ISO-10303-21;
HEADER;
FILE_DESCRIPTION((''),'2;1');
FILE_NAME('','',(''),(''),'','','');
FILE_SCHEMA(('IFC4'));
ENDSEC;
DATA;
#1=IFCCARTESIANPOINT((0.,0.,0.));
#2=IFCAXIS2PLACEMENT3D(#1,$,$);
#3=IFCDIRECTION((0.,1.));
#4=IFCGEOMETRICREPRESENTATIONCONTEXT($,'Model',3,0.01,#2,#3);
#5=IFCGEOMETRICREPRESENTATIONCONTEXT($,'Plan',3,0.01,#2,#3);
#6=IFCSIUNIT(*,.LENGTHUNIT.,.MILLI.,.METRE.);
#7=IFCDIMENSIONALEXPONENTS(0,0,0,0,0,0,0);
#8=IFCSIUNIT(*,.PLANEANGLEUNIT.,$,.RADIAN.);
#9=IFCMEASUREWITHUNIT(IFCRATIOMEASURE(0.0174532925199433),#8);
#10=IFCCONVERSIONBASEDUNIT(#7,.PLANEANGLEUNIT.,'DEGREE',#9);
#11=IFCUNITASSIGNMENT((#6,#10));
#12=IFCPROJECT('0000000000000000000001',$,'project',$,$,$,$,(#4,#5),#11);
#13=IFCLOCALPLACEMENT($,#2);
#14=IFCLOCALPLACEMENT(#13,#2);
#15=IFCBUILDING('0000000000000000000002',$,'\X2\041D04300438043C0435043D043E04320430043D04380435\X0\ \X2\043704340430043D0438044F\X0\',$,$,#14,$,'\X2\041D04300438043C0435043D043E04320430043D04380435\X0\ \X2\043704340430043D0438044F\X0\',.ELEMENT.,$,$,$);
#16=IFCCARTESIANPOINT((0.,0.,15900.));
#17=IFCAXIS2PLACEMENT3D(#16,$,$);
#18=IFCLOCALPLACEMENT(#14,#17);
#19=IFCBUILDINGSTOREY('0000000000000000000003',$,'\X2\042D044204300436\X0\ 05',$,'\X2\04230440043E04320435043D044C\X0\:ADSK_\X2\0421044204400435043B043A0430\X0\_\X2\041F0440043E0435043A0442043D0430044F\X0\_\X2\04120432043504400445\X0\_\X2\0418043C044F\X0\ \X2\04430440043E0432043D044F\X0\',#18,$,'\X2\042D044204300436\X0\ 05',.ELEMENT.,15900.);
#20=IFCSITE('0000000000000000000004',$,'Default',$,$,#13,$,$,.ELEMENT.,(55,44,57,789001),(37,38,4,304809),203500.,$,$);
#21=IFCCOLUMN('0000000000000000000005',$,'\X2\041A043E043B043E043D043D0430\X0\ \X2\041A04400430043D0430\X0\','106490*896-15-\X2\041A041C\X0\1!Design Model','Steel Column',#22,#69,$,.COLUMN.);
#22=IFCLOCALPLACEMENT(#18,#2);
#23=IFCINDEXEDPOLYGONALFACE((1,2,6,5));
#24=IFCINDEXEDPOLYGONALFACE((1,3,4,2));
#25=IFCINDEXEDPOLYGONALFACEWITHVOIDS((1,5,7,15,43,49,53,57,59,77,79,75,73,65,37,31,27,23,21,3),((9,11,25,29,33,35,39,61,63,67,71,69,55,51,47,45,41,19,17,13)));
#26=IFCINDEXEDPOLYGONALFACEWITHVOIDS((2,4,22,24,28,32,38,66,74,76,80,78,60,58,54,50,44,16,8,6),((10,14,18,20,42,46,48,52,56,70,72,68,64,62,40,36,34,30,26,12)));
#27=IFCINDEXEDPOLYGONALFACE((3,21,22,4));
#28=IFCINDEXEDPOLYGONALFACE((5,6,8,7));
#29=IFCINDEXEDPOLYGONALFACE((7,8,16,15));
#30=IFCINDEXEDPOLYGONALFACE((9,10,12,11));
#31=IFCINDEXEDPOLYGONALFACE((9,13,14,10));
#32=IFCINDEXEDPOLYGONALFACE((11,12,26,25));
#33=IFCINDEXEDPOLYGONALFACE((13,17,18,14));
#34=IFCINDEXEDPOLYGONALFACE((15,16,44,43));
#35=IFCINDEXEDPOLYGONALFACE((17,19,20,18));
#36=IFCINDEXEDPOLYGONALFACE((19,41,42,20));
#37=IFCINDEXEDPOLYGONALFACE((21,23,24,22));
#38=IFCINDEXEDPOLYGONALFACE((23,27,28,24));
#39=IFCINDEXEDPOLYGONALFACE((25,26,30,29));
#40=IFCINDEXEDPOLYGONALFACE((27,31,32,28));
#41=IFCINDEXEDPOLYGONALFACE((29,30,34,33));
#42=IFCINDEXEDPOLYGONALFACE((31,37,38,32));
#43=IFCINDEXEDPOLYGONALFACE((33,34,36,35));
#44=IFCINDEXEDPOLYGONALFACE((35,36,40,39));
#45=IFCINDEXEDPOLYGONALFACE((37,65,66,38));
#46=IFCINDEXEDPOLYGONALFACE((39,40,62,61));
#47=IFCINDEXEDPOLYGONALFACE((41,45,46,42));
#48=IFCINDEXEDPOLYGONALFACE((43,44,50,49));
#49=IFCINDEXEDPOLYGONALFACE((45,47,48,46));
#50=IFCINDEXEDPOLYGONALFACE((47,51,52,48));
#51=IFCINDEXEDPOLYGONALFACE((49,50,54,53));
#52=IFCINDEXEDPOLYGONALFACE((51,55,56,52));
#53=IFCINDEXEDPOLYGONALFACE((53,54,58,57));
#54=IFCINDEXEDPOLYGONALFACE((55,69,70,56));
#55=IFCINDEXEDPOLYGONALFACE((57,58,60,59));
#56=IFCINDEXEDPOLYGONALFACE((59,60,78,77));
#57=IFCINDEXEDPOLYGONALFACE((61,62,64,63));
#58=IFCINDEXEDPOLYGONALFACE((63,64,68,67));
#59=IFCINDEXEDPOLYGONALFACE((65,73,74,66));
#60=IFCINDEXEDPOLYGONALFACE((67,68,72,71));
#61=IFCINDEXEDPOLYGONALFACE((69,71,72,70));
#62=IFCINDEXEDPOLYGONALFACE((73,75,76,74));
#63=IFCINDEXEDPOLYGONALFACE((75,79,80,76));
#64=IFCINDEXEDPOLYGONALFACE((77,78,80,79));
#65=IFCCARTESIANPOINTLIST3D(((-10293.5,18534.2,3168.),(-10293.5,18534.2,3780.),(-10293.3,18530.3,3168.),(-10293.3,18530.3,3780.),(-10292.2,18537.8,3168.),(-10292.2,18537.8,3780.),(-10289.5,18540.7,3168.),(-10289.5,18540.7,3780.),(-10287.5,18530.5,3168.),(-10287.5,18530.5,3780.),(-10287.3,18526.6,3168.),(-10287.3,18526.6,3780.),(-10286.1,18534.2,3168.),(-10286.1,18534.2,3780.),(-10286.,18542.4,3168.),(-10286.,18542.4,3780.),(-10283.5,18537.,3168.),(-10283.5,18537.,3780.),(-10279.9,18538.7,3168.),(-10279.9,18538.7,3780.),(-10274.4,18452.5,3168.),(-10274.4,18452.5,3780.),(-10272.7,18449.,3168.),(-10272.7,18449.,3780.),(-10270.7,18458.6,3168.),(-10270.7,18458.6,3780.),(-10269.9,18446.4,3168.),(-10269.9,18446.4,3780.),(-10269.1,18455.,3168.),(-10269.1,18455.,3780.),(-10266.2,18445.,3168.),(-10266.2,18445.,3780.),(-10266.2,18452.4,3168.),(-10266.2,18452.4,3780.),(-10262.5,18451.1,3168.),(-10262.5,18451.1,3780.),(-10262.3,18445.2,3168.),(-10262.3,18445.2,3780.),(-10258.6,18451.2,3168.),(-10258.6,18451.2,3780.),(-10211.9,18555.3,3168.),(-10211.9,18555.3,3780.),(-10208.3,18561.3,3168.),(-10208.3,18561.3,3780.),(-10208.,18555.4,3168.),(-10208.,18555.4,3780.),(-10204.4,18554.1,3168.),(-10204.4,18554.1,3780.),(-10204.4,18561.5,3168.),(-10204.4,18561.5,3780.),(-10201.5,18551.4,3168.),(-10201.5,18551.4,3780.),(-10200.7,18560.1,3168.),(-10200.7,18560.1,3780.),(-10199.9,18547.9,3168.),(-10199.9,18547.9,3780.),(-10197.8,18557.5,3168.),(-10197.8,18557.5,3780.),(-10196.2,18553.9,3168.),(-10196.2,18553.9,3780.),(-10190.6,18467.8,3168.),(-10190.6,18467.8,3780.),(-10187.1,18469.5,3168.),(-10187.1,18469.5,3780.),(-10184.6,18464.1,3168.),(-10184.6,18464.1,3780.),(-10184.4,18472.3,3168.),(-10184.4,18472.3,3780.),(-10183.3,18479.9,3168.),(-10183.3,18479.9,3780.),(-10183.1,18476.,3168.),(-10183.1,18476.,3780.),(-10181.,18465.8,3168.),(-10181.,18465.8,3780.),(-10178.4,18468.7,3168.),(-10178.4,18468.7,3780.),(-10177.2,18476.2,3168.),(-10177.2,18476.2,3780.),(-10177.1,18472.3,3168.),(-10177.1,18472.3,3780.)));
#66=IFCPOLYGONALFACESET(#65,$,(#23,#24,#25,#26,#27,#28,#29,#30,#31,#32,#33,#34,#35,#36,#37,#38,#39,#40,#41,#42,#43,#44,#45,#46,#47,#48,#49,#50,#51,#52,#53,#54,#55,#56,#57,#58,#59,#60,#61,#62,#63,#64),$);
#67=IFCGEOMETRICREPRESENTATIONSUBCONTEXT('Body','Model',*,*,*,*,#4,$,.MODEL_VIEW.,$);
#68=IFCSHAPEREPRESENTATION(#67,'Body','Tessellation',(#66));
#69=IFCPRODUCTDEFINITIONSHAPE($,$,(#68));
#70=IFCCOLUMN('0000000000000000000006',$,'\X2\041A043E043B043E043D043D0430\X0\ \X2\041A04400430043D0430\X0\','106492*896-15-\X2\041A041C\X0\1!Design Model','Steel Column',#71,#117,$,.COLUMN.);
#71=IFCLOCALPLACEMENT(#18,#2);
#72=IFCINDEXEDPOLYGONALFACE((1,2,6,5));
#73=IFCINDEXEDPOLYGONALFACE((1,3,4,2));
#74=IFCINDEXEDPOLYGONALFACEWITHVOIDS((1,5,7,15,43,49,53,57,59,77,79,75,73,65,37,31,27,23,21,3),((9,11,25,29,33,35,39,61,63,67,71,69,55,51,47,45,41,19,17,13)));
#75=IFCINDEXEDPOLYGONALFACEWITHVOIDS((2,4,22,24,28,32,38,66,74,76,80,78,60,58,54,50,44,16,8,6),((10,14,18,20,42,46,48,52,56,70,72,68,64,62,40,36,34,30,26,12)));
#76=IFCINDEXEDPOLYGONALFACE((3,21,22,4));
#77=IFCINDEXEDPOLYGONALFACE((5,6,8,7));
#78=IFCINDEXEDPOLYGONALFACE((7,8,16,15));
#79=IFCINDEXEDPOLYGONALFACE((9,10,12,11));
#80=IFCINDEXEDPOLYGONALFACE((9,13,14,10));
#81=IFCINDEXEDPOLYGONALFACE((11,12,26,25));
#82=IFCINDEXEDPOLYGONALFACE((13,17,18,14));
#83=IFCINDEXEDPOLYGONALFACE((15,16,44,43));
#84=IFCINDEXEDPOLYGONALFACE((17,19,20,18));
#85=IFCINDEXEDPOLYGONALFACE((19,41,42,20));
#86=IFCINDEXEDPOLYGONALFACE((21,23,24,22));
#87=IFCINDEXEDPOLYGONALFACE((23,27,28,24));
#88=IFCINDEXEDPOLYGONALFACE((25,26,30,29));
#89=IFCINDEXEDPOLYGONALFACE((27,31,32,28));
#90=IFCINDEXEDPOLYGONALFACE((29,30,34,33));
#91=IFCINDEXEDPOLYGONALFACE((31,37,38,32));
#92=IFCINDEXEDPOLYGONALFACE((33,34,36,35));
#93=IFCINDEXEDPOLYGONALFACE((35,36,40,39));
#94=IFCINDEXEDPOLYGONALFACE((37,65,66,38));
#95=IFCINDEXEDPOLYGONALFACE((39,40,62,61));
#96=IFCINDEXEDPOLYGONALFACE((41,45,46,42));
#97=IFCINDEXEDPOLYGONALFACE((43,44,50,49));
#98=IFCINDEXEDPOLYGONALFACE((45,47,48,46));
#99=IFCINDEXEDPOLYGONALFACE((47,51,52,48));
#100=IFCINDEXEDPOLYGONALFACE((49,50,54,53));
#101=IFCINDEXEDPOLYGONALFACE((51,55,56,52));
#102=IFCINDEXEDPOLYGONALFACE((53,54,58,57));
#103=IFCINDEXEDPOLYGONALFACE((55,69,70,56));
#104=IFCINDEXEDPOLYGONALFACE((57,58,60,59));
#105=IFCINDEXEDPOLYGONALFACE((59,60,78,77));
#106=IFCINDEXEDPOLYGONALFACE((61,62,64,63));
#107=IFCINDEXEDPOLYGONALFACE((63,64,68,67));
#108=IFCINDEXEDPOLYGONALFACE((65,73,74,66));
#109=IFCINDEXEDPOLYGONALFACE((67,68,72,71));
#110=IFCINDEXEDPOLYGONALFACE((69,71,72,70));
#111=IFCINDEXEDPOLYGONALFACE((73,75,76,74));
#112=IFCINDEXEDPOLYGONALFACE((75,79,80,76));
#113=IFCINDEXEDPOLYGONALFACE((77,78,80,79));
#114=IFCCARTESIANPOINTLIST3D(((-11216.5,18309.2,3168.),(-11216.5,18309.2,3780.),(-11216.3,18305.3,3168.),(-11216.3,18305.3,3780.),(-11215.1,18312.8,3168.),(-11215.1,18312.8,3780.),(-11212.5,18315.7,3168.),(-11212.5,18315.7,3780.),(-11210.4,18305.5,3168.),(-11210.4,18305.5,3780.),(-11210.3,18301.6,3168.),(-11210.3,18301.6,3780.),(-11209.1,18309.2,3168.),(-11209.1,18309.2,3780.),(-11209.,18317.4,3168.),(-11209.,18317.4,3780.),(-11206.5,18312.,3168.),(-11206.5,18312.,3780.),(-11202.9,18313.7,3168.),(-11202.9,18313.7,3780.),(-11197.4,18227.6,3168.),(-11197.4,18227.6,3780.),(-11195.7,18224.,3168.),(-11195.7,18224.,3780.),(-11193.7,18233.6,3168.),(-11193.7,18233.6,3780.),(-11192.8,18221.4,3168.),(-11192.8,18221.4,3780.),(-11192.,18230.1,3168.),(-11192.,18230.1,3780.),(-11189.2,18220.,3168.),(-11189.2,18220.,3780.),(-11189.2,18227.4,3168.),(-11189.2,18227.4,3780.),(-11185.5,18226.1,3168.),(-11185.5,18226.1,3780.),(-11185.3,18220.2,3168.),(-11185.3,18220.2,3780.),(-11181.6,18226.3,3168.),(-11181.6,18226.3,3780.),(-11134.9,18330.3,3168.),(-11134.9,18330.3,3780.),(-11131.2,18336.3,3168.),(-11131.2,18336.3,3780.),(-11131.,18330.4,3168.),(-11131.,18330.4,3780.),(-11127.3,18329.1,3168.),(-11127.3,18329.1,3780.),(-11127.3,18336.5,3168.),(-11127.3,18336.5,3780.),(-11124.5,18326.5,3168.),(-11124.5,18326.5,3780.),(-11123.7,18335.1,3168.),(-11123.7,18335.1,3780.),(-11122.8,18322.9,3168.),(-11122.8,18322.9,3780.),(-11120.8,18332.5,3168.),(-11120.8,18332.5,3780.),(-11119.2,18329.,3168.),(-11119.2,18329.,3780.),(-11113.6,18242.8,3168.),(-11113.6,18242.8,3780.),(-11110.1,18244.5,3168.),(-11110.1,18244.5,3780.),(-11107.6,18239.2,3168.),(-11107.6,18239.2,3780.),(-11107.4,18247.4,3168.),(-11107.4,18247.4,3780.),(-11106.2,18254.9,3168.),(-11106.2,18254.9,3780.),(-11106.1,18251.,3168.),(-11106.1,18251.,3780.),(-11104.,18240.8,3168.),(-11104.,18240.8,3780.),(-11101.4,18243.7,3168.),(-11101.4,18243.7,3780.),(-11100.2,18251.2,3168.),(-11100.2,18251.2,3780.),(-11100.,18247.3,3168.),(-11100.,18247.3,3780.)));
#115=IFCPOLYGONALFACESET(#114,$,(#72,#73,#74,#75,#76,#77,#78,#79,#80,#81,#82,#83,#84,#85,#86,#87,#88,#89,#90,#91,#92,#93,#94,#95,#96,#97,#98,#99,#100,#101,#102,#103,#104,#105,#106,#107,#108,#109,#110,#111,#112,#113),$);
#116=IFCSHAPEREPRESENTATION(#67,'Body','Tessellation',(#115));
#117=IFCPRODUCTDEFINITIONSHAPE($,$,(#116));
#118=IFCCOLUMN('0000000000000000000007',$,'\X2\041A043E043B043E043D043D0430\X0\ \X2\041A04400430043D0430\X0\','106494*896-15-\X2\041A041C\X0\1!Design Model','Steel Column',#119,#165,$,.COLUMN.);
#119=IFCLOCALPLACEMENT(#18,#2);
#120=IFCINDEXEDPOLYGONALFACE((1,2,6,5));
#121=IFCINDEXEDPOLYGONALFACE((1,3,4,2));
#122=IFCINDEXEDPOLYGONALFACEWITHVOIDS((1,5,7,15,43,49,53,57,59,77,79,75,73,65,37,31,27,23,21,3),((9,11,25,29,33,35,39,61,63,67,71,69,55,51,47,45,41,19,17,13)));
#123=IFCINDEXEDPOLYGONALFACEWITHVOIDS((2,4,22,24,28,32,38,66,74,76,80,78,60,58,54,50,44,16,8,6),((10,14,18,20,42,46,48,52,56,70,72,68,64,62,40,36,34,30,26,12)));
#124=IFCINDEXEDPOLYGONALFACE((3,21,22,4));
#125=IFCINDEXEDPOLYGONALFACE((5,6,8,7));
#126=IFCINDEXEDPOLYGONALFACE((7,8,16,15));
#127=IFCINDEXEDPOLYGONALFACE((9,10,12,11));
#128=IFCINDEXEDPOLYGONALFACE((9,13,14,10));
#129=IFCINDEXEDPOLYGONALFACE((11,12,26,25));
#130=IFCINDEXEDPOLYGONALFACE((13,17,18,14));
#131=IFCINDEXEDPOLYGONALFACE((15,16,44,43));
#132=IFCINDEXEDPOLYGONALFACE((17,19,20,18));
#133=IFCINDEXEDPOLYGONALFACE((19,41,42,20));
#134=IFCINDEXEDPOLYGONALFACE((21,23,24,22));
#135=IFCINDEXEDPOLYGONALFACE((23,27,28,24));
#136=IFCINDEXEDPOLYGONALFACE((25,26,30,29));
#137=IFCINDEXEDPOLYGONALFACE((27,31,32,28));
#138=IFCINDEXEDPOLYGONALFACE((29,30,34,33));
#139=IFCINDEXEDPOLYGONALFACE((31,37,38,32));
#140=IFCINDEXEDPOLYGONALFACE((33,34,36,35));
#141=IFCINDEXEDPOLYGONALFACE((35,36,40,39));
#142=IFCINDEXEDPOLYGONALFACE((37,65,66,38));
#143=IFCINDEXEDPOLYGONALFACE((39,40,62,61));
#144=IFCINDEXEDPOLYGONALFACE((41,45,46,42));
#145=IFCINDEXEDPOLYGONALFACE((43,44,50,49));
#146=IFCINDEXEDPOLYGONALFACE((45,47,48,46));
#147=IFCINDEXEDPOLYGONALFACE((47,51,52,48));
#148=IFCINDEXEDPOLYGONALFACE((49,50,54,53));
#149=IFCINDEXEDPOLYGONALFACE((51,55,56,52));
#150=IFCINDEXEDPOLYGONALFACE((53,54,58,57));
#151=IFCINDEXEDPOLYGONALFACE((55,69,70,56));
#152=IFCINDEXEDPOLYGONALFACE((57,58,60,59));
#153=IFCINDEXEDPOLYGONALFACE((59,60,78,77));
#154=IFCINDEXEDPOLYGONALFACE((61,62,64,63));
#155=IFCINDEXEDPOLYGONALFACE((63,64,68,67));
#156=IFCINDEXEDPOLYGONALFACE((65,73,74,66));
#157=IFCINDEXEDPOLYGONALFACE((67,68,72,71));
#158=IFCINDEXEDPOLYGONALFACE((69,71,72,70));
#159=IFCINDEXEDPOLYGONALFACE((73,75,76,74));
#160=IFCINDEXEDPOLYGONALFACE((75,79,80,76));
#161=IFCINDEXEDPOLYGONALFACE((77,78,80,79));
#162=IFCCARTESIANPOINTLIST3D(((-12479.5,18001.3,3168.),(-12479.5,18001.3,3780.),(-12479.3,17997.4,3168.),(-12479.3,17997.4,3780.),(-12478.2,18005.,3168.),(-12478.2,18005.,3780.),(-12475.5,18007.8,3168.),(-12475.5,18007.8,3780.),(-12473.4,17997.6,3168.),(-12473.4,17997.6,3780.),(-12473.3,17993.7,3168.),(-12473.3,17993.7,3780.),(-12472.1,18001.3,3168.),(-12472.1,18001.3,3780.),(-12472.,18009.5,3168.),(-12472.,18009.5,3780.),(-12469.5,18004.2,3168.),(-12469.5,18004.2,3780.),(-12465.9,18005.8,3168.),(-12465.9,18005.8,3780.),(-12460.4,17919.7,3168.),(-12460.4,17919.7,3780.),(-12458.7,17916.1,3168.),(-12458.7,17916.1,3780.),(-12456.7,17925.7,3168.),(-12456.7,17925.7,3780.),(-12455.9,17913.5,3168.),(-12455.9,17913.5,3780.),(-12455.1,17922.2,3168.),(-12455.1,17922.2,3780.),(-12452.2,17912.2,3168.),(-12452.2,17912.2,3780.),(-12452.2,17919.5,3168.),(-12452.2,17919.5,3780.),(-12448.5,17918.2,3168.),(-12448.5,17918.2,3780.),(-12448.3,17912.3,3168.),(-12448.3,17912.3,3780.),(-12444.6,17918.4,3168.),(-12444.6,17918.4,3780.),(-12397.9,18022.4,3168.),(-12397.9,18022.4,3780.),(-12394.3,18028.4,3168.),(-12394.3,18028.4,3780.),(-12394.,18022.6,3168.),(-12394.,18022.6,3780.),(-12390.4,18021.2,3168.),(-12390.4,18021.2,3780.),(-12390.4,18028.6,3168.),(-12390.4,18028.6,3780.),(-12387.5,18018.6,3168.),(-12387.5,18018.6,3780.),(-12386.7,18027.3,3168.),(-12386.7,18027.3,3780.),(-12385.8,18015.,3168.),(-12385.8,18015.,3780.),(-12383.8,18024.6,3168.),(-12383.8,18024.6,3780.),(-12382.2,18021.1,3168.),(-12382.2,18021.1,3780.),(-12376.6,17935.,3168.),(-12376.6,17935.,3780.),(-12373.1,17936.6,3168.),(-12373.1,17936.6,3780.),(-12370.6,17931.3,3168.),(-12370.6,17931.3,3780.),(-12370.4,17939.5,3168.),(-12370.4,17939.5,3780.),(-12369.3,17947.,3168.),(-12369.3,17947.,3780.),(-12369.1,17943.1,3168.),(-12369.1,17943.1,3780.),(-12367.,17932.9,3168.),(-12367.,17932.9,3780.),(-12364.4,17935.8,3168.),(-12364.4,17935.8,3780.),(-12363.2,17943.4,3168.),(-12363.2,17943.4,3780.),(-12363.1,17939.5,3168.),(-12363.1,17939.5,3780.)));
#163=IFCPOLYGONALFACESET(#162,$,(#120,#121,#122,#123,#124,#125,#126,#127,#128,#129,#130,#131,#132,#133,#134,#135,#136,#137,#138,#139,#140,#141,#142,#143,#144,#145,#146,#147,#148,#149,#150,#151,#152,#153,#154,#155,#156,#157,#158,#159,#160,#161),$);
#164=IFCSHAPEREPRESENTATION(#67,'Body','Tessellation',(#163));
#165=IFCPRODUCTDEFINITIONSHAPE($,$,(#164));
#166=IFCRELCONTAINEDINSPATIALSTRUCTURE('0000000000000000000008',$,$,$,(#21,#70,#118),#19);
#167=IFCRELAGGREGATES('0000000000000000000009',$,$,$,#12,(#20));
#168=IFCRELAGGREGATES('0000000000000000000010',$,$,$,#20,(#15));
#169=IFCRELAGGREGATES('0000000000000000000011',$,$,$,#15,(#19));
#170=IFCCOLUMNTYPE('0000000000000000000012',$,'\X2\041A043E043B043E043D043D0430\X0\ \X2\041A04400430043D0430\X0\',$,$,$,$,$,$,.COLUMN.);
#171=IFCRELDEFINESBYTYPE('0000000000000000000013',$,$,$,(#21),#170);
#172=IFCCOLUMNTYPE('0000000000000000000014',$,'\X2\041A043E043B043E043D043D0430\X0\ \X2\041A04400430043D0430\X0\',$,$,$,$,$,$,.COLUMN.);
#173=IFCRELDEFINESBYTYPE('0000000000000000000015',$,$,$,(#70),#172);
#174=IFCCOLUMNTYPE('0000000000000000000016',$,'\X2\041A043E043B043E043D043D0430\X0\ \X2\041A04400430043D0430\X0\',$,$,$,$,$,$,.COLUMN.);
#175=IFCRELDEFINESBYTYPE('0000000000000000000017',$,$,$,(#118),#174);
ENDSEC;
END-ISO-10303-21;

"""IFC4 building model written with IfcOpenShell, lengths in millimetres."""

from ifc_helpers import new_model, entity, si_unit, converted_unit, direction, frame, origin, place, context, subcontext, project, spatial, indexed_curve, outline, extrude, type_object, element, save


model = new_model("IFC4")

# Units and contexts
model_context = context("Model", 3, precision=0.01, world=origin(), true_north=direction((0.0, 1.0)))
plan_context = context("Plan", 3, precision=0.01, world=origin(), true_north=direction((0.0, 1.0)))
body_context = subcontext(model_context, "Body", "Model", "MODEL_VIEW")
ifc_project = project(units=[si_unit("LENGTHUNIT", "METRE", prefix="MILLI"), converted_unit("PLANEANGLEUNIT", "DEGREE", entity("IfcRatioMeasure", 0.0174532925199433), si_unit("PLANEANGLEUNIT", "RADIAN"), dimensions=[0, 0, 0, 0, 0, 0, 0])], contexts=[model_context, plan_context])

# Site, building, storey
site_placement = place(None, origin())
site = spatial("IfcSite", under=ifc_project, at=site_placement, Name="Default", CompositionType="ELEMENT", RefLatitude=(55, 44, 57, 789001), RefLongitude=(37, 38, 4, 304809), RefElevation=203500.0)
building_placement = place(site_placement, origin())
building = spatial("IfcBuilding", under=site, at=building_placement, Name="Наименование здания", LongName="Наименование здания", CompositionType="ELEMENT")
storey_placement = place(building_placement, frame((0.0, 0.0, 15900.0)))
storey = spatial("IfcBuildingStorey", under=building, at=storey_placement, Name="Этаж 05", ObjectType="Уровень:ADSK_Стрелка_Проектная_Вверх_Имя уровня", LongName="Этаж 05", CompositionType="ELEMENT", Elevation=15900.0)

# Columns
column_type_1 = type_object("IfcColumnType", Name="Колонна Крана", PredefinedType="COLUMN")
column_1_placement = place(storey_placement, origin())
element("IfcColumn", 1, at=column_1_placement, inside=storey, type_object=column_type_1, Name="Колонна Крана", Description="106490*896-15-КМ1!Design Model", ObjectType="Steel Column", PredefinedType="COLUMN", context=body_context, shape_type="SweptSolid", body=[
    extrude(outline(indexed_curve([(29.5, -56.8), (33.4, -56.8), (37.0, -55.3), (39.7, -52.6), (41.2, -49.0), (56.8, 29.5), (56.8, 33.4), (55.3, 37.0), (52.6, 39.7), (49.0, 41.2), (-29.5, 56.8), (-33.4, 56.8), (-37.0, 55.3), (-39.7, 52.6), (-41.2, 49.0), (-56.8, -29.5), (-56.8, -33.4), (-55.3, -37.0), (-52.6, -39.7), (-49.0, -41.2), (29.5, -56.8)], self_intersect=False), holes=[indexed_curve([(-43.1, -37.3), (-46.7, -35.8), (-49.5, -33.1), (-51.0, -29.5), (-51.0, -25.5), (-37.3, 43.1), (-35.8, 46.7), (-33.1, 49.5), (-29.5, 51.0), (-25.5, 51.0), (43.1, 37.3), (46.7, 35.8), (49.5, 33.1), (51.0, 29.5), (51.0, 25.5), (37.3, -43.1), (35.8, -46.7), (33.1, -49.5), (29.5, -51.0), (25.5, -51.0), (-43.1, -37.3)], self_intersect=False)]), frame((-10235.3, 18503.2, 3168.0), z_axis=(0.0, 0.0, 1.0), x_axis=(0.906681, 0.421816, 0.0)), (0.0, 0.0, 1.0), 612.0),
])
column_type_2 = type_object("IfcColumnType", Name="Колонна Крана", PredefinedType="COLUMN")
column_2_placement = place(storey_placement, origin())
element("IfcColumn", 2, at=column_2_placement, inside=storey, type_object=column_type_2, Name="Колонна Крана", Description="106492*896-15-КМ1!Design Model", ObjectType="Steel Column", PredefinedType="COLUMN", context=body_context, shape_type="SweptSolid", body=[
    extrude(outline(indexed_curve([(29.5, -56.8), (33.4, -56.8), (37.0, -55.3), (39.7, -52.6), (41.2, -49.0), (56.8, 29.5), (56.8, 33.4), (55.3, 37.0), (52.6, 39.7), (49.0, 41.2), (-29.5, 56.8), (-33.4, 56.8), (-37.0, 55.3), (-39.7, 52.6), (-41.2, 49.0), (-56.8, -29.5), (-56.8, -33.4), (-55.3, -37.0), (-52.6, -39.7), (-49.0, -41.2), (29.5, -56.8)], self_intersect=False), holes=[indexed_curve([(-43.1, -37.3), (-46.7, -35.8), (-49.5, -33.1), (-51.0, -29.5), (-51.0, -25.5), (-37.3, 43.1), (-35.8, 46.7), (-33.1, 49.5), (-29.5, 51.0), (-25.5, 51.0), (43.1, 37.3), (46.7, 35.8), (49.5, 33.1), (51.0, 29.5), (51.0, 25.5), (37.3, -43.1), (35.8, -46.7), (33.1, -49.5), (29.5, -51.0), (25.5, -51.0), (-43.1, -37.3)], self_intersect=False)]), frame((-11158.3, 18278.3, 3168.0), z_axis=(0.0, 0.0, 1.0), x_axis=(0.906681, 0.421816, 0.0)), (0.0, 0.0, 1.0), 612.0),
])
column_type_3 = type_object("IfcColumnType", Name="Колонна Крана", PredefinedType="COLUMN")
column_3_placement = place(storey_placement, origin())
element("IfcColumn", 3, at=column_3_placement, inside=storey, type_object=column_type_3, Name="Колонна Крана", Description="106494*896-15-КМ1!Design Model", ObjectType="Steel Column", PredefinedType="COLUMN", context=body_context, shape_type="SweptSolid", body=[
    extrude(outline(indexed_curve([(29.5, -56.8), (33.4, -56.8), (37.0, -55.3), (39.7, -52.6), (41.2, -49.0), (56.8, 29.5), (56.8, 33.4), (55.3, 37.0), (52.6, 39.7), (49.0, 41.2), (-29.5, 56.8), (-33.4, 56.8), (-37.0, 55.3), (-39.7, 52.6), (-41.2, 49.0), (-56.8, -29.5), (-56.8, -33.4), (-55.3, -37.0), (-52.6, -39.7), (-49.0, -41.2), (29.5, -56.8)], self_intersect=False), holes=[indexed_curve([(-43.1, -37.3), (-46.7, -35.8), (-49.5, -33.1), (-51.0, -29.5), (-51.0, -25.5), (-37.3, 43.1), (-35.8, 46.7), (-33.1, 49.5), (-29.5, 51.0), (-25.5, 51.0), (43.1, 37.3), (46.7, 35.8), (49.5, 33.1), (51.0, 29.5), (51.0, 25.5), (37.3, -43.1), (35.8, -46.7), (33.1, -49.5), (29.5, -51.0), (25.5, -51.0), (-43.1, -37.3)], self_intersect=False)]), frame((-12421.3, 17970.4, 3168.0), z_axis=(0.0, 0.0, 1.0), x_axis=(0.906681, 0.421816, 0.0)), (0.0, 0.0, 1.0), 612.0),
])

save(model, "model.ifc")
